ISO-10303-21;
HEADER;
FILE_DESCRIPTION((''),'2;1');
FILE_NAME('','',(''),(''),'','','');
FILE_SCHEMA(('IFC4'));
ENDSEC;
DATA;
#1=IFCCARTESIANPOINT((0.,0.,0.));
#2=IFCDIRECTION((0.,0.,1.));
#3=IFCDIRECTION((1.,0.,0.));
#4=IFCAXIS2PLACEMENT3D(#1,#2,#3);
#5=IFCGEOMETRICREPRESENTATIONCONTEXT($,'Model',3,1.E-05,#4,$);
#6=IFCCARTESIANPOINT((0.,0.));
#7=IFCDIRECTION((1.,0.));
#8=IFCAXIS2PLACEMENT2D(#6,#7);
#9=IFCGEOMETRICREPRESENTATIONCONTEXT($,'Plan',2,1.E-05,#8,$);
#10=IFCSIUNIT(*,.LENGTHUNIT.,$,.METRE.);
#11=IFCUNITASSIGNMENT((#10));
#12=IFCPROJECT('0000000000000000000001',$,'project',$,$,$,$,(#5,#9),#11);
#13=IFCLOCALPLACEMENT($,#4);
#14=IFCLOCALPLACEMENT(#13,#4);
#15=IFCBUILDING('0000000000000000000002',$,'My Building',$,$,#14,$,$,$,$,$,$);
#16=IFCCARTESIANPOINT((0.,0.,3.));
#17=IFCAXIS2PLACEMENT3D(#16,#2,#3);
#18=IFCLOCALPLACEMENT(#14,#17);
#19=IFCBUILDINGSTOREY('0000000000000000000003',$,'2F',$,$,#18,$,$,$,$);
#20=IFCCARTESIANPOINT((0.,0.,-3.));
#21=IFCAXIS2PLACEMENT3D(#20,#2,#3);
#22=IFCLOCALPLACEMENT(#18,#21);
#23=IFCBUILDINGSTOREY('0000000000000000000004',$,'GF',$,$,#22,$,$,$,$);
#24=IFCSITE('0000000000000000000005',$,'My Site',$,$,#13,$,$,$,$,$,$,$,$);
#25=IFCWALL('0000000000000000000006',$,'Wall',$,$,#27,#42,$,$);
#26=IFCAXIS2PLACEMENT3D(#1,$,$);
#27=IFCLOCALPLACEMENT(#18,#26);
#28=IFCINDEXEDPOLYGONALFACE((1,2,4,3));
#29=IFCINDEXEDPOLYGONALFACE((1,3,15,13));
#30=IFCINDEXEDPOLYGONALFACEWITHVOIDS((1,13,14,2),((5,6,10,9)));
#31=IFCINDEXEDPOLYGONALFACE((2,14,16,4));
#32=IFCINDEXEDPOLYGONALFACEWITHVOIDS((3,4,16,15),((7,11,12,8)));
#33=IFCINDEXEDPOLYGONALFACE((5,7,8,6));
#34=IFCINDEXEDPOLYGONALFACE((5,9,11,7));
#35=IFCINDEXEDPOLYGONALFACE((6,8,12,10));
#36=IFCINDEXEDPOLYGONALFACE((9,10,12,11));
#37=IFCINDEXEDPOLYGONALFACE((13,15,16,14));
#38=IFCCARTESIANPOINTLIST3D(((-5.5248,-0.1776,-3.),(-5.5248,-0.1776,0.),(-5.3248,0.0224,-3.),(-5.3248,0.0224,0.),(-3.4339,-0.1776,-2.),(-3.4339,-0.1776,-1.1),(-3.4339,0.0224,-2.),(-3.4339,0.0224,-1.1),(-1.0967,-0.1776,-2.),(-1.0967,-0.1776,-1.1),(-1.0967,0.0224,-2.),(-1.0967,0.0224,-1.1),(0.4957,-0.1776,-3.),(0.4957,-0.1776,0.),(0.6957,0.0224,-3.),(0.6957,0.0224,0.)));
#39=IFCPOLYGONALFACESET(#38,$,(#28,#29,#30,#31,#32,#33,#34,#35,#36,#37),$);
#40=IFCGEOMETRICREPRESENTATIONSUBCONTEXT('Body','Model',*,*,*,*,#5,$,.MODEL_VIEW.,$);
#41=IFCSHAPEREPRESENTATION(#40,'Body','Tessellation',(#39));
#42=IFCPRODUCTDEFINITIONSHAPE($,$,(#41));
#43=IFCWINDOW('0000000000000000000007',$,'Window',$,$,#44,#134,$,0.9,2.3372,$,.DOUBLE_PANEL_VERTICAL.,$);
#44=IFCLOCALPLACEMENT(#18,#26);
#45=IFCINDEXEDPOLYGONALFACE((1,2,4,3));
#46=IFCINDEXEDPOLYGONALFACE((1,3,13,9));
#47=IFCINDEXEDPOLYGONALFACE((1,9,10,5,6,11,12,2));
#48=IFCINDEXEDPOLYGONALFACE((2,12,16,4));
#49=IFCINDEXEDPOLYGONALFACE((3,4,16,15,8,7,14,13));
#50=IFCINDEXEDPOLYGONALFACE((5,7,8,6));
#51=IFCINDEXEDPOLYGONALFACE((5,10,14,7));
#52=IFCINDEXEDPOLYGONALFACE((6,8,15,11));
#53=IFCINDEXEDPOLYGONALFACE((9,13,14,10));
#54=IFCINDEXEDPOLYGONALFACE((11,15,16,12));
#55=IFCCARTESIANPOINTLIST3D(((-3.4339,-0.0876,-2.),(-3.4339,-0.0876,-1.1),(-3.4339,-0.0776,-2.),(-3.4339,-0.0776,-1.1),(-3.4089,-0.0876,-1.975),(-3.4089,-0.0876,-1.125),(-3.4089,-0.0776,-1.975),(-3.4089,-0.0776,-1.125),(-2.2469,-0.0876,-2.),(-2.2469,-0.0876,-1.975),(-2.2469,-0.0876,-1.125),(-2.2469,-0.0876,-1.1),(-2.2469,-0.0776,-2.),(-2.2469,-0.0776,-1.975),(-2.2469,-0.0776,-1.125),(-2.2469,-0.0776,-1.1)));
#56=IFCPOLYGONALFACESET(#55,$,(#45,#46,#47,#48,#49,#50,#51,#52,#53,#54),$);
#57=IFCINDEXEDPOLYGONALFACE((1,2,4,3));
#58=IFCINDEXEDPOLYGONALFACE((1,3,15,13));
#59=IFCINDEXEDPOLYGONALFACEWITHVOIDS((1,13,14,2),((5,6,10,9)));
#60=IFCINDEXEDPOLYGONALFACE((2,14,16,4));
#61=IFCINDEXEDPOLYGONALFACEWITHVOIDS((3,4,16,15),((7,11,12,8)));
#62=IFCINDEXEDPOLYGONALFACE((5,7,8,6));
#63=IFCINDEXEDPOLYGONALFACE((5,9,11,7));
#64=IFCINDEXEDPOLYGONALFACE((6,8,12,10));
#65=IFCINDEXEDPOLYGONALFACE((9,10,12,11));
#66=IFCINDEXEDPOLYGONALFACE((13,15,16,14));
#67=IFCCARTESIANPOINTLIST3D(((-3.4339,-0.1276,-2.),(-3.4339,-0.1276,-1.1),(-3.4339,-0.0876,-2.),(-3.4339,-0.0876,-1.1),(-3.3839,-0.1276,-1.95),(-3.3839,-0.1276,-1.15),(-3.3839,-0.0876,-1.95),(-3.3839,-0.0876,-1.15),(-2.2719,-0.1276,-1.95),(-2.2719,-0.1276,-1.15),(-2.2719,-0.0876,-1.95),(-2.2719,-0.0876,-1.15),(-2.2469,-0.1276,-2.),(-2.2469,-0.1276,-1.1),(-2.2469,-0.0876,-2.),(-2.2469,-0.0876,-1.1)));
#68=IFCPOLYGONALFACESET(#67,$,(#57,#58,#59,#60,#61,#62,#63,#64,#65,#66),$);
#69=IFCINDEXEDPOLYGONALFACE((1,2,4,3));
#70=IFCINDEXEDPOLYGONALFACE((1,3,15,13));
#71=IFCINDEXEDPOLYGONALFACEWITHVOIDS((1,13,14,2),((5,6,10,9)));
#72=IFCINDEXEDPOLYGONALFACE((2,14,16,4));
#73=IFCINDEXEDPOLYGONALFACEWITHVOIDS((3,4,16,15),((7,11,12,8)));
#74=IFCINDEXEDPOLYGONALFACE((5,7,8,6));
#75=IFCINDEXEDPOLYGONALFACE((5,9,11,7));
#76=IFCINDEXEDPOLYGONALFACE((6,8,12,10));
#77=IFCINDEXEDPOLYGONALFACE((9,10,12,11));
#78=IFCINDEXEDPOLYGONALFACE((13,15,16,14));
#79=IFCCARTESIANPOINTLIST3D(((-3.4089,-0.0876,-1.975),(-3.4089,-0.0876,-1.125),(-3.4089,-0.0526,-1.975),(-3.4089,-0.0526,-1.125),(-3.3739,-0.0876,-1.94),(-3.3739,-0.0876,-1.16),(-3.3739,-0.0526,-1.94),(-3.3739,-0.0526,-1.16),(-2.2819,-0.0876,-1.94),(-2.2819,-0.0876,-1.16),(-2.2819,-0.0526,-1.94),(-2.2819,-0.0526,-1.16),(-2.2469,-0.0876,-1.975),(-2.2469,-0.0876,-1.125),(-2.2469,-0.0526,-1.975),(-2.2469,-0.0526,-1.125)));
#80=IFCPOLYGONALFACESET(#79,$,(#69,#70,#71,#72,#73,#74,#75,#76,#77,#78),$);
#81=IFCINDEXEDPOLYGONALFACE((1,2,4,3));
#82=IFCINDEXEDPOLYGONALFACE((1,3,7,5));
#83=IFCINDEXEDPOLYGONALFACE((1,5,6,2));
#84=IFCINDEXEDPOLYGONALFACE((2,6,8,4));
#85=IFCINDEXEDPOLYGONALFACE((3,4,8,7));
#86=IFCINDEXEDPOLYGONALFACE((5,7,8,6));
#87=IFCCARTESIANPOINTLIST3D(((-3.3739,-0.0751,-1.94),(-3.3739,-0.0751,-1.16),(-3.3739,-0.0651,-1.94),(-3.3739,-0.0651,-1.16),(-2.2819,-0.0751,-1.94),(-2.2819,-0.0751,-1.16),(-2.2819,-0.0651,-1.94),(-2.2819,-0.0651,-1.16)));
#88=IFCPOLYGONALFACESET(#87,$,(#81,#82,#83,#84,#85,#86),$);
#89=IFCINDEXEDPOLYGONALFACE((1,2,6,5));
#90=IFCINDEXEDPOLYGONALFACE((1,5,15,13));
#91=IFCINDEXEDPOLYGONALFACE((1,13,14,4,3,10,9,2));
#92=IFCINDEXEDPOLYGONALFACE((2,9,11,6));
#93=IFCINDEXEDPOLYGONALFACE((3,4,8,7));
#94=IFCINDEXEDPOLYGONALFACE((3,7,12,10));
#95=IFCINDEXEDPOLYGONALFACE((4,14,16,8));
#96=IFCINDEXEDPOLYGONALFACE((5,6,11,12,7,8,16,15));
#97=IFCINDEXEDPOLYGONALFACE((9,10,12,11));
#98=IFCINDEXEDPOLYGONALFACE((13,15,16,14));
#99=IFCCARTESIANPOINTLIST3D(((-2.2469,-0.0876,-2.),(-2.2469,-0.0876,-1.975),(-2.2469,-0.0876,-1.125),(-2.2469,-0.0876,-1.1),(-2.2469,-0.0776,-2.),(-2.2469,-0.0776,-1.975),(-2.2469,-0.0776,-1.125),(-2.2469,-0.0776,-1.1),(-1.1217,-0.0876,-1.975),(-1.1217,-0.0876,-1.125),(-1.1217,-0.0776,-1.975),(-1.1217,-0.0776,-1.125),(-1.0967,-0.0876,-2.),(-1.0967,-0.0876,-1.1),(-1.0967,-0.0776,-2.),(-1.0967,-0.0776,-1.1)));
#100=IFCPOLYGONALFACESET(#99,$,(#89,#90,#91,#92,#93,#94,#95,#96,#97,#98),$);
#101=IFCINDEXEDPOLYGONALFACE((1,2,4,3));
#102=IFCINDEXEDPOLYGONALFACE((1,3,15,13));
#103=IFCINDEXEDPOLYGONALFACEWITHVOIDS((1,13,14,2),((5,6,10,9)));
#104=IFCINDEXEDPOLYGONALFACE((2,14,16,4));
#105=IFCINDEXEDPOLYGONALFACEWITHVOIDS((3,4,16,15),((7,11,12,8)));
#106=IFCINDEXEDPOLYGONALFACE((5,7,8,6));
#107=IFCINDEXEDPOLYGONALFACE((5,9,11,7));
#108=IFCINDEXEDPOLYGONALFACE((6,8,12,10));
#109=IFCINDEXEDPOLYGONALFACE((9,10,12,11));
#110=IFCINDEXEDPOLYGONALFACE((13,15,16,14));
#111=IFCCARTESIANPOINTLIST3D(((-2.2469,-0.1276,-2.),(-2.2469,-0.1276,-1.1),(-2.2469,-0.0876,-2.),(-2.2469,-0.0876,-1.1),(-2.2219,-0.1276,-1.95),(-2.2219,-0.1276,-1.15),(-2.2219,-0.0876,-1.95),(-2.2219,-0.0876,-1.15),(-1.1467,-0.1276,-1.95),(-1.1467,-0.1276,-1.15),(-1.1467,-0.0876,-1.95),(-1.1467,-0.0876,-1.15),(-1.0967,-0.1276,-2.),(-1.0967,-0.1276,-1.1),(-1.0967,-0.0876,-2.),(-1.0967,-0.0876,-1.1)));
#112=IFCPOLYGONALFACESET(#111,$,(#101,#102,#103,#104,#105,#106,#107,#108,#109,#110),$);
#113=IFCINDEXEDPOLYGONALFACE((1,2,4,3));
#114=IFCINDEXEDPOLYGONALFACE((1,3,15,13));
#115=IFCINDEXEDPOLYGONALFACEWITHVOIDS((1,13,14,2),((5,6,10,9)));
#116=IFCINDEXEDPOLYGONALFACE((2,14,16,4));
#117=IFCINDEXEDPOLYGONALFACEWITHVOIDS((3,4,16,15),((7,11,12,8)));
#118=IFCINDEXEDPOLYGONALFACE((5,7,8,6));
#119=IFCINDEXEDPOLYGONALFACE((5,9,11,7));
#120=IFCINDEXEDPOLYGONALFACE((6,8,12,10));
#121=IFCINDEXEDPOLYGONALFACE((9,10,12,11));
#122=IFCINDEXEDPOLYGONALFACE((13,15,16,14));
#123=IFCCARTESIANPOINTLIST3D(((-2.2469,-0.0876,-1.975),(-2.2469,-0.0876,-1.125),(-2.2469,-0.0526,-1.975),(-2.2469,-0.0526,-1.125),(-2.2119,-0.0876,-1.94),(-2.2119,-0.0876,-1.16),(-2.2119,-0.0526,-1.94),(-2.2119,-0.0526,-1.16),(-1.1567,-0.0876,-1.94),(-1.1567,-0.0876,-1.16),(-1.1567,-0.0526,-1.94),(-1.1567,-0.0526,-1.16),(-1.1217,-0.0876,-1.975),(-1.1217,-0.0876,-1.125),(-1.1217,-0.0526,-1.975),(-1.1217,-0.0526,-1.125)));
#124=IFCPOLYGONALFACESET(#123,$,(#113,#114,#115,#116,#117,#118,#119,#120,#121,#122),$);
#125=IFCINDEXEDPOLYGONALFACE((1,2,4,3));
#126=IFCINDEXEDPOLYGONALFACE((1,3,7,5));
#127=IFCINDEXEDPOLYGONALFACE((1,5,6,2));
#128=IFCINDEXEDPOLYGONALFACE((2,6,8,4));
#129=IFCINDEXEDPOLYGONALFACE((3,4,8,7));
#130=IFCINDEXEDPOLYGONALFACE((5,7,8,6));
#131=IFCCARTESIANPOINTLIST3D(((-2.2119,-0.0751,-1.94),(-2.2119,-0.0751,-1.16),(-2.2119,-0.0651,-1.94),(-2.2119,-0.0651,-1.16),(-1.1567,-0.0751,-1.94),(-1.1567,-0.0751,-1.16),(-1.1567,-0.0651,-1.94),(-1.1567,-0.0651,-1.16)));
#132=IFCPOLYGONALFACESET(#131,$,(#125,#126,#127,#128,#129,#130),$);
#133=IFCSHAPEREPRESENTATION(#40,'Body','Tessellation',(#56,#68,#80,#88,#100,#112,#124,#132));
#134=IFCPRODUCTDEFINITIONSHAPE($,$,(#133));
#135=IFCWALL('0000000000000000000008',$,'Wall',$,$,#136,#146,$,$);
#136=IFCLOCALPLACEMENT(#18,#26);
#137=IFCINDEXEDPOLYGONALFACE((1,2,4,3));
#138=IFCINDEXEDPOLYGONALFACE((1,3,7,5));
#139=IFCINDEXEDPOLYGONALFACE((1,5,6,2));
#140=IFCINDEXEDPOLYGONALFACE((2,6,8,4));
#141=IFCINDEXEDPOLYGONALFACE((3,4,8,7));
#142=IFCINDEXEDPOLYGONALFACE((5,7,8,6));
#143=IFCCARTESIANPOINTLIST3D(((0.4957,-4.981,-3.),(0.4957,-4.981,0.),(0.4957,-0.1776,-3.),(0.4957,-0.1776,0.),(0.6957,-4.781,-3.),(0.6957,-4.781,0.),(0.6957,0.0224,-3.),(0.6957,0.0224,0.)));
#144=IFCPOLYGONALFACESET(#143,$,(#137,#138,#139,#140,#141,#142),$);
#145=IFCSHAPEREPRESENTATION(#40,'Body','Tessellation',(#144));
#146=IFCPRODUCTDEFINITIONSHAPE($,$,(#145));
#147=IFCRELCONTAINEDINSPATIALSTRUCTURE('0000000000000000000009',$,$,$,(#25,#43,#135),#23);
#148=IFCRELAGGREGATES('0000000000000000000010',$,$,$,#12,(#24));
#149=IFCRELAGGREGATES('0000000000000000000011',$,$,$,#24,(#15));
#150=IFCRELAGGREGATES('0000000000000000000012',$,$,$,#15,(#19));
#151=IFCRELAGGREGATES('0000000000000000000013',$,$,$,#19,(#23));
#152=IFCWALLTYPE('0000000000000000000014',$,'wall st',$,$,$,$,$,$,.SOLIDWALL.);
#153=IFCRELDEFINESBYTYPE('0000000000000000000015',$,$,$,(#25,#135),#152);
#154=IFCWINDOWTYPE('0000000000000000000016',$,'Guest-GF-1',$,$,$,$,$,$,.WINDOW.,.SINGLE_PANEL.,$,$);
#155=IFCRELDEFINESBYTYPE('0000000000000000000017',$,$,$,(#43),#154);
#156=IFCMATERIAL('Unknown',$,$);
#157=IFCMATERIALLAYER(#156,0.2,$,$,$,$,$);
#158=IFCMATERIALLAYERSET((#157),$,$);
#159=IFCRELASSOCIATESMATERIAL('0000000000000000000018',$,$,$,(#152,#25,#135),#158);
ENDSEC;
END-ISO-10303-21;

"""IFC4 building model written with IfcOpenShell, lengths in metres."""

from ifc_helpers import new_model, entity, si_unit, frame, origin_with_axes, origin_2d_with_axis, place, context, subcontext, project, spatial, line, indexed_curve, outline, extrude, shape, source, transform, mapped, material, layer, layer_set, layer_usage, type_object, type_shapes, element, fill, save


model = new_model("IFC4")

# Units and contexts
model_context = context("Model", 3, precision=1e-05, world=origin_with_axes())
plan_context = context("Plan", 2, precision=1e-05, world=origin_2d_with_axis())
body_context_1 = subcontext(model_context, "Body", "Model", "MODEL_VIEW")
body_context_2 = subcontext(plan_context, "Body", "Plan", "PLAN_VIEW")
ifc_project = project(units=[si_unit("LENGTHUNIT", "METRE")], contexts=[model_context, plan_context])

# Site, building, storeys
site_placement = place(None, origin_with_axes())
site = spatial("IfcSite", under=ifc_project, at=site_placement, Name="My Site")
building_placement = place(site_placement, origin_with_axes())
building = spatial("IfcBuilding", under=site, at=building_placement, Name="My Building")
storey_1_placement = place(building_placement, frame((0.0, 0.0, 3.0), z_axis=(0.0, 0.0, 1.0), x_axis=(1.0, 0.0, 0.0)))
storey_1 = spatial("IfcBuildingStorey", under=building, at=storey_1_placement, Name="2F")
storey_2_placement = place(storey_1_placement, frame((0.0, 0.0, -3.0), z_axis=(0.0, 0.0, 1.0), x_axis=(1.0, 0.0, 0.0)))
storey_2 = spatial("IfcBuildingStorey", under=storey_1, at=storey_2_placement, Name="GF")

# Shared definitions
ifc_material = material(Name="Unknown")

# Shared definitions
ifc_layer_1 = layer(ifc_material, 0.2)
ifc_layer_set_1 = layer_set([ifc_layer_1])
wall_type = type_object("IfcWallType", Name="wall st", PredefinedType="SOLIDWALL", material=ifc_layer_set_1)

# Wall, opening, window
ifc_layer_usage_1 = layer_usage(ifc_layer_set_1, "AXIS2", "POSITIVE", 0.0)
wall_1_placement = place(storey_2_placement, frame((-5.5248, -0.1776, 0.0), z_axis=(0.0, 0.0, 1.0), x_axis=(1.0, 0.0, 0.0)))
wall_1 = element("IfcWall", 1, at=wall_1_placement, inside=storey_2, type_object=wall_type, material=ifc_layer_usage_1, Name="Wall", context=body_context_1, shape_type="SweptSolid", body=[
    extrude(outline(indexed_curve([(0.0, 0.0), (0.2, 0.2), (6.2205, 0.2), (6.0205, 0.0)], segments=[line(1, 2, 3, 4, 1)])), origin_with_axes(), (0.0, 0.0, 1.0), 3.0),
])
shared_shape_1 = source(origin_with_axes(), body_context_1, "Body", "SweptSolid", [
    extrude(outline(indexed_curve([(0.0, 0.0), (2.3372, 0.0), (2.3372, 0.9), (0.0, 0.9)], segments=[line(1, 2, 3, 4, 1)])), frame((0.0, -0.6, 0.0), z_axis=(0.0, -1.0, 0.0), x_axis=(1.0, 0.0, 0.0)), (0.0, 0.0, -1.0), 1.2),
])
opening_1_placement = place(wall_1_placement, frame((2.0909, 0.0, 1.0), z_axis=(0.0, 0.0, 1.0), x_axis=(1.0, 0.0, 0.0)))
opening_1 = element("IfcOpeningElement", 2, at=opening_1_placement, cuts=wall_1, PredefinedType="OPENING", context=body_context_1, shape_type="MappedRepresentation", body=[
    mapped(shared_shape_1, transform((0.0, 0.0, 0.0), x_axis=(1.0, 0.0, 0.0), y_axis=(0.0, 1.0, 0.0), z_axis=(0.0, 0.0, 1.0), scale=1.0)),
])
window_type_1 = type_object("IfcWindowType", Name="Guest-GF-1", PartitioningType="SINGLE_PANEL", PredefinedType="WINDOW")
shared_shape_2 = source(origin_with_axes(), body_context_1, "Body", "SweptSolid", [
    extrude(outline(indexed_curve([(1.187, 0.0), (0.0, 0.0), (0.0, 0.9), (1.187, 0.9), (1.187, 0.875), (0.025, 0.875), (0.025, 0.025), (1.187, 0.025)], segments=[line(1, 2, 3, 4, 5, 6, 7, 8, 1)])), frame((0.0, 0.09, 0.0), z_axis=(0.0, -1.0, 0.0), x_axis=(1.0, 0.0, 0.0)), (0.0, 0.0, -1.0), 0.01),
    extrude(outline(indexed_curve([(0.0, 0.0), (1.187, 0.0), (1.187, 0.9), (0.0, 0.9)], segments=[line(1, 2, 3, 4, 1)]), holes=[indexed_curve([(0.05, 0.05), (1.162, 0.05), (1.162, 0.85), (0.05, 0.85)], segments=[line(1, 2, 3, 4, 1)])]), frame((0.0, 0.05, 0.0), z_axis=(0.0, -1.0, 0.0), x_axis=(1.0, 0.0, 0.0)), (0.0, 0.0, -1.0), 0.04),
    extrude(outline(indexed_curve([(0.0, 0.0), (1.162, 0.0), (1.162, 0.85), (0.0, 0.85)], segments=[line(1, 2, 3, 4, 1)]), holes=[indexed_curve([(0.035, 0.035), (1.127, 0.035), (1.127, 0.815), (0.035, 0.815)], segments=[line(1, 2, 3, 4, 1)])]), frame((0.025, 0.09, 0.025), z_axis=(0.0, -1.0, 0.0), x_axis=(1.0, 0.0, 0.0)), (0.0, 0.0, -1.0), 0.035),
    extrude(outline(indexed_curve([(0.035, 0.035), (1.127, 0.035), (1.127, 0.815), (0.035, 0.815)], segments=[line(1, 2, 3, 4, 1)])), frame((0.025, 0.1025, 0.025), z_axis=(0.0, -1.0, 0.0), x_axis=(1.0, 0.0, 0.0)), (0.0, 0.0, -1.0), 0.01),
    extrude(outline(indexed_curve([(0.0, 0.9), (1.1502, 0.9), (1.1502, 0.0), (0.0, 0.0), (0.0, 0.025), (1.1252, 0.025), (1.1252, 0.875), (0.0, 0.875)], segments=[line(1, 2, 3, 4, 5, 6, 7, 8, 1)])), frame((1.187, 0.09, 0.0), z_axis=(0.0, -1.0, 0.0), x_axis=(1.0, 0.0, 0.0)), (0.0, 0.0, -1.0), 0.01),
    extrude(outline(indexed_curve([(0.0, 0.0), (1.1502, 0.0), (1.1502, 0.9), (0.0, 0.9)], segments=[line(1, 2, 3, 4, 1)]), holes=[indexed_curve([(0.025, 0.05), (1.1002, 0.05), (1.1002, 0.85), (0.025, 0.85)], segments=[line(1, 2, 3, 4, 1)])]), frame((1.187, 0.05, 0.0), z_axis=(0.0, -1.0, 0.0), x_axis=(1.0, 0.0, 0.0)), (0.0, 0.0, -1.0), 0.04),
    extrude(outline(indexed_curve([(0.0, 0.0), (1.1252, 0.0), (1.1252, 0.85), (0.0, 0.85)], segments=[line(1, 2, 3, 4, 1)]), holes=[indexed_curve([(0.035, 0.035), (1.0902, 0.035), (1.0902, 0.815), (0.035, 0.815)], segments=[line(1, 2, 3, 4, 1)])]), frame((1.187, 0.09, 0.025), z_axis=(0.0, -1.0, 0.0), x_axis=(1.0, 0.0, 0.0)), (0.0, 0.0, -1.0), 0.035),
    extrude(outline(indexed_curve([(0.035, 0.035), (1.0902, 0.035), (1.0902, 0.815), (0.035, 0.815)], segments=[line(1, 2, 3, 4, 1)])), frame((1.187, 0.1025, 0.025), z_axis=(0.0, -1.0, 0.0), x_axis=(1.0, 0.0, 0.0)), (0.0, 0.0, -1.0), 0.01),
])
shared_shape_3 = source(origin_with_axes(), body_context_2, "Body", "Curve2D", [
    entity("IfcIndexedPolyCurve", entity("IfcCartesianPointList2D", [[0.05, 0.05], [1.162, 0.05]])),
    entity("IfcIndexedPolyCurve", entity("IfcCartesianPointList2D", [[0.0, 0.1], [0.025, 0.1], [0.025, 0.09], [0.05, 0.09], [0.05, 0.05], [0.0, 0.05]]), [entity("IfcLineIndex", [1, 2, 3, 4, 5, 6, 1])]),
    entity("IfcIndexedPolyCurve", entity("IfcCartesianPointList2D", [[1.187, 0.1], [1.187, 0.1], [1.187, 0.09], [1.162, 0.09], [1.162, 0.05], [1.187, 0.05]])),
    entity("IfcIndexedPolyCurve", entity("IfcCartesianPointList2D", [[0.025, 0.09], [0.06, 0.09], [0.06, 0.125], [0.025, 0.125]]), [entity("IfcLineIndex", [1, 2, 3, 4, 1])]),
    entity("IfcIndexedPolyCurve", entity("IfcCartesianPointList2D", [[1.187, 0.09], [1.152, 0.09], [1.152, 0.125], [1.187, 0.125]]), [entity("IfcLineIndex", [1, 2, 3, 4, 1])]),
    entity("IfcIndexedPolyCurve", entity("IfcCartesianPointList2D", [[0.06, 0.09], [1.152, 0.09]])),
    entity("IfcIndexedPolyCurve", entity("IfcCartesianPointList2D", [[0.06, 0.125], [1.152, 0.125]])),
    entity("IfcIndexedPolyCurve", entity("IfcCartesianPointList2D", [[0.06, 0.1075], [1.152, 0.1075]])),
    entity("IfcIndexedPolyCurve", entity("IfcCartesianPointList2D", [[1.212, 0.05], [2.2872, 0.05]])),
    entity("IfcIndexedPolyCurve", entity("IfcCartesianPointList2D", [[1.187, 0.1], [1.187, 0.1], [1.187, 0.09], [1.212, 0.09], [1.212, 0.05], [1.187, 0.05]])),
    entity("IfcIndexedPolyCurve", entity("IfcCartesianPointList2D", [[2.3372, 0.1], [2.3122, 0.1], [2.3122, 0.09], [2.2872, 0.09], [2.2872, 0.05], [2.3372, 0.05]]), [entity("IfcLineIndex", [1, 2, 3, 4, 5, 6, 1])]),
    entity("IfcIndexedPolyCurve", entity("IfcCartesianPointList2D", [[1.187, 0.09], [1.222, 0.09], [1.222, 0.125], [1.187, 0.125]]), [entity("IfcLineIndex", [1, 2, 3, 4, 1])]),
    entity("IfcIndexedPolyCurve", entity("IfcCartesianPointList2D", [[2.3122, 0.09], [2.2772, 0.09], [2.2772, 0.125], [2.3122, 0.125]]), [entity("IfcLineIndex", [1, 2, 3, 4, 1])]),
    entity("IfcIndexedPolyCurve", entity("IfcCartesianPointList2D", [[1.222, 0.09], [2.2772, 0.09]])),
    entity("IfcIndexedPolyCurve", entity("IfcCartesianPointList2D", [[1.222, 0.125], [2.2772, 0.125]])),
    entity("IfcIndexedPolyCurve", entity("IfcCartesianPointList2D", [[1.222, 0.1075], [2.2772, 0.1075]])),
])
type_shapes(window_type_1, [shared_shape_2, shared_shape_3])
window_1_placement = place(opening_1_placement, origin_with_axes())
window_1 = element("IfcWindow", 3, at=window_1_placement, inside=storey_2, type_object=window_type_1, Name="Window", OverallHeight=0.9, OverallWidth=2.3372, PartitioningType="DOUBLE_PANEL_VERTICAL", shapes=[
    shape(body_context_1, "Body", "MappedRepresentation", [mapped(shared_shape_2, transform((0.0, 0.0, 0.0), x_axis=(1.0, 0.0, 0.0), y_axis=(0.0, 1.0, 0.0), z_axis=(0.0, 0.0, 1.0), scale=1.0))]),
    shape(body_context_2, "Body", "MappedRepresentation", [mapped(shared_shape_3, transform((0.0, 0.0, 0.0), x_axis=(1.0, 0.0, 0.0), y_axis=(0.0, 1.0, 0.0), z_axis=(0.0, 0.0, 1.0), scale=1.0))]),
])
fill(opening_1, window_1)

# Wall
ifc_layer_usage_2 = layer_usage(ifc_layer_set_1, "AXIS2", "POSITIVE", 0.0)
wall_2_placement = place(storey_2_placement, frame((0.4957, -0.1776, 0.0), z_axis=(0.0, 0.0, 1.0), x_axis=(0.0, -1.0, 0.0)))
element("IfcWall", 4, at=wall_2_placement, inside=storey_2, type_object=wall_type, material=ifc_layer_usage_2, Name="Wall", context=body_context_1, shape_type="SweptSolid", body=[
    extrude(outline(indexed_curve([(0.0, 0.0), (-0.2, 0.2), (4.6033, 0.2), (4.8033, 0.0)], segments=[line(1, 2, 3, 4, 1)])), origin_with_axes(), (0.0, 0.0, 1.0), 3.0),
])

save(model, "model.ifc")
